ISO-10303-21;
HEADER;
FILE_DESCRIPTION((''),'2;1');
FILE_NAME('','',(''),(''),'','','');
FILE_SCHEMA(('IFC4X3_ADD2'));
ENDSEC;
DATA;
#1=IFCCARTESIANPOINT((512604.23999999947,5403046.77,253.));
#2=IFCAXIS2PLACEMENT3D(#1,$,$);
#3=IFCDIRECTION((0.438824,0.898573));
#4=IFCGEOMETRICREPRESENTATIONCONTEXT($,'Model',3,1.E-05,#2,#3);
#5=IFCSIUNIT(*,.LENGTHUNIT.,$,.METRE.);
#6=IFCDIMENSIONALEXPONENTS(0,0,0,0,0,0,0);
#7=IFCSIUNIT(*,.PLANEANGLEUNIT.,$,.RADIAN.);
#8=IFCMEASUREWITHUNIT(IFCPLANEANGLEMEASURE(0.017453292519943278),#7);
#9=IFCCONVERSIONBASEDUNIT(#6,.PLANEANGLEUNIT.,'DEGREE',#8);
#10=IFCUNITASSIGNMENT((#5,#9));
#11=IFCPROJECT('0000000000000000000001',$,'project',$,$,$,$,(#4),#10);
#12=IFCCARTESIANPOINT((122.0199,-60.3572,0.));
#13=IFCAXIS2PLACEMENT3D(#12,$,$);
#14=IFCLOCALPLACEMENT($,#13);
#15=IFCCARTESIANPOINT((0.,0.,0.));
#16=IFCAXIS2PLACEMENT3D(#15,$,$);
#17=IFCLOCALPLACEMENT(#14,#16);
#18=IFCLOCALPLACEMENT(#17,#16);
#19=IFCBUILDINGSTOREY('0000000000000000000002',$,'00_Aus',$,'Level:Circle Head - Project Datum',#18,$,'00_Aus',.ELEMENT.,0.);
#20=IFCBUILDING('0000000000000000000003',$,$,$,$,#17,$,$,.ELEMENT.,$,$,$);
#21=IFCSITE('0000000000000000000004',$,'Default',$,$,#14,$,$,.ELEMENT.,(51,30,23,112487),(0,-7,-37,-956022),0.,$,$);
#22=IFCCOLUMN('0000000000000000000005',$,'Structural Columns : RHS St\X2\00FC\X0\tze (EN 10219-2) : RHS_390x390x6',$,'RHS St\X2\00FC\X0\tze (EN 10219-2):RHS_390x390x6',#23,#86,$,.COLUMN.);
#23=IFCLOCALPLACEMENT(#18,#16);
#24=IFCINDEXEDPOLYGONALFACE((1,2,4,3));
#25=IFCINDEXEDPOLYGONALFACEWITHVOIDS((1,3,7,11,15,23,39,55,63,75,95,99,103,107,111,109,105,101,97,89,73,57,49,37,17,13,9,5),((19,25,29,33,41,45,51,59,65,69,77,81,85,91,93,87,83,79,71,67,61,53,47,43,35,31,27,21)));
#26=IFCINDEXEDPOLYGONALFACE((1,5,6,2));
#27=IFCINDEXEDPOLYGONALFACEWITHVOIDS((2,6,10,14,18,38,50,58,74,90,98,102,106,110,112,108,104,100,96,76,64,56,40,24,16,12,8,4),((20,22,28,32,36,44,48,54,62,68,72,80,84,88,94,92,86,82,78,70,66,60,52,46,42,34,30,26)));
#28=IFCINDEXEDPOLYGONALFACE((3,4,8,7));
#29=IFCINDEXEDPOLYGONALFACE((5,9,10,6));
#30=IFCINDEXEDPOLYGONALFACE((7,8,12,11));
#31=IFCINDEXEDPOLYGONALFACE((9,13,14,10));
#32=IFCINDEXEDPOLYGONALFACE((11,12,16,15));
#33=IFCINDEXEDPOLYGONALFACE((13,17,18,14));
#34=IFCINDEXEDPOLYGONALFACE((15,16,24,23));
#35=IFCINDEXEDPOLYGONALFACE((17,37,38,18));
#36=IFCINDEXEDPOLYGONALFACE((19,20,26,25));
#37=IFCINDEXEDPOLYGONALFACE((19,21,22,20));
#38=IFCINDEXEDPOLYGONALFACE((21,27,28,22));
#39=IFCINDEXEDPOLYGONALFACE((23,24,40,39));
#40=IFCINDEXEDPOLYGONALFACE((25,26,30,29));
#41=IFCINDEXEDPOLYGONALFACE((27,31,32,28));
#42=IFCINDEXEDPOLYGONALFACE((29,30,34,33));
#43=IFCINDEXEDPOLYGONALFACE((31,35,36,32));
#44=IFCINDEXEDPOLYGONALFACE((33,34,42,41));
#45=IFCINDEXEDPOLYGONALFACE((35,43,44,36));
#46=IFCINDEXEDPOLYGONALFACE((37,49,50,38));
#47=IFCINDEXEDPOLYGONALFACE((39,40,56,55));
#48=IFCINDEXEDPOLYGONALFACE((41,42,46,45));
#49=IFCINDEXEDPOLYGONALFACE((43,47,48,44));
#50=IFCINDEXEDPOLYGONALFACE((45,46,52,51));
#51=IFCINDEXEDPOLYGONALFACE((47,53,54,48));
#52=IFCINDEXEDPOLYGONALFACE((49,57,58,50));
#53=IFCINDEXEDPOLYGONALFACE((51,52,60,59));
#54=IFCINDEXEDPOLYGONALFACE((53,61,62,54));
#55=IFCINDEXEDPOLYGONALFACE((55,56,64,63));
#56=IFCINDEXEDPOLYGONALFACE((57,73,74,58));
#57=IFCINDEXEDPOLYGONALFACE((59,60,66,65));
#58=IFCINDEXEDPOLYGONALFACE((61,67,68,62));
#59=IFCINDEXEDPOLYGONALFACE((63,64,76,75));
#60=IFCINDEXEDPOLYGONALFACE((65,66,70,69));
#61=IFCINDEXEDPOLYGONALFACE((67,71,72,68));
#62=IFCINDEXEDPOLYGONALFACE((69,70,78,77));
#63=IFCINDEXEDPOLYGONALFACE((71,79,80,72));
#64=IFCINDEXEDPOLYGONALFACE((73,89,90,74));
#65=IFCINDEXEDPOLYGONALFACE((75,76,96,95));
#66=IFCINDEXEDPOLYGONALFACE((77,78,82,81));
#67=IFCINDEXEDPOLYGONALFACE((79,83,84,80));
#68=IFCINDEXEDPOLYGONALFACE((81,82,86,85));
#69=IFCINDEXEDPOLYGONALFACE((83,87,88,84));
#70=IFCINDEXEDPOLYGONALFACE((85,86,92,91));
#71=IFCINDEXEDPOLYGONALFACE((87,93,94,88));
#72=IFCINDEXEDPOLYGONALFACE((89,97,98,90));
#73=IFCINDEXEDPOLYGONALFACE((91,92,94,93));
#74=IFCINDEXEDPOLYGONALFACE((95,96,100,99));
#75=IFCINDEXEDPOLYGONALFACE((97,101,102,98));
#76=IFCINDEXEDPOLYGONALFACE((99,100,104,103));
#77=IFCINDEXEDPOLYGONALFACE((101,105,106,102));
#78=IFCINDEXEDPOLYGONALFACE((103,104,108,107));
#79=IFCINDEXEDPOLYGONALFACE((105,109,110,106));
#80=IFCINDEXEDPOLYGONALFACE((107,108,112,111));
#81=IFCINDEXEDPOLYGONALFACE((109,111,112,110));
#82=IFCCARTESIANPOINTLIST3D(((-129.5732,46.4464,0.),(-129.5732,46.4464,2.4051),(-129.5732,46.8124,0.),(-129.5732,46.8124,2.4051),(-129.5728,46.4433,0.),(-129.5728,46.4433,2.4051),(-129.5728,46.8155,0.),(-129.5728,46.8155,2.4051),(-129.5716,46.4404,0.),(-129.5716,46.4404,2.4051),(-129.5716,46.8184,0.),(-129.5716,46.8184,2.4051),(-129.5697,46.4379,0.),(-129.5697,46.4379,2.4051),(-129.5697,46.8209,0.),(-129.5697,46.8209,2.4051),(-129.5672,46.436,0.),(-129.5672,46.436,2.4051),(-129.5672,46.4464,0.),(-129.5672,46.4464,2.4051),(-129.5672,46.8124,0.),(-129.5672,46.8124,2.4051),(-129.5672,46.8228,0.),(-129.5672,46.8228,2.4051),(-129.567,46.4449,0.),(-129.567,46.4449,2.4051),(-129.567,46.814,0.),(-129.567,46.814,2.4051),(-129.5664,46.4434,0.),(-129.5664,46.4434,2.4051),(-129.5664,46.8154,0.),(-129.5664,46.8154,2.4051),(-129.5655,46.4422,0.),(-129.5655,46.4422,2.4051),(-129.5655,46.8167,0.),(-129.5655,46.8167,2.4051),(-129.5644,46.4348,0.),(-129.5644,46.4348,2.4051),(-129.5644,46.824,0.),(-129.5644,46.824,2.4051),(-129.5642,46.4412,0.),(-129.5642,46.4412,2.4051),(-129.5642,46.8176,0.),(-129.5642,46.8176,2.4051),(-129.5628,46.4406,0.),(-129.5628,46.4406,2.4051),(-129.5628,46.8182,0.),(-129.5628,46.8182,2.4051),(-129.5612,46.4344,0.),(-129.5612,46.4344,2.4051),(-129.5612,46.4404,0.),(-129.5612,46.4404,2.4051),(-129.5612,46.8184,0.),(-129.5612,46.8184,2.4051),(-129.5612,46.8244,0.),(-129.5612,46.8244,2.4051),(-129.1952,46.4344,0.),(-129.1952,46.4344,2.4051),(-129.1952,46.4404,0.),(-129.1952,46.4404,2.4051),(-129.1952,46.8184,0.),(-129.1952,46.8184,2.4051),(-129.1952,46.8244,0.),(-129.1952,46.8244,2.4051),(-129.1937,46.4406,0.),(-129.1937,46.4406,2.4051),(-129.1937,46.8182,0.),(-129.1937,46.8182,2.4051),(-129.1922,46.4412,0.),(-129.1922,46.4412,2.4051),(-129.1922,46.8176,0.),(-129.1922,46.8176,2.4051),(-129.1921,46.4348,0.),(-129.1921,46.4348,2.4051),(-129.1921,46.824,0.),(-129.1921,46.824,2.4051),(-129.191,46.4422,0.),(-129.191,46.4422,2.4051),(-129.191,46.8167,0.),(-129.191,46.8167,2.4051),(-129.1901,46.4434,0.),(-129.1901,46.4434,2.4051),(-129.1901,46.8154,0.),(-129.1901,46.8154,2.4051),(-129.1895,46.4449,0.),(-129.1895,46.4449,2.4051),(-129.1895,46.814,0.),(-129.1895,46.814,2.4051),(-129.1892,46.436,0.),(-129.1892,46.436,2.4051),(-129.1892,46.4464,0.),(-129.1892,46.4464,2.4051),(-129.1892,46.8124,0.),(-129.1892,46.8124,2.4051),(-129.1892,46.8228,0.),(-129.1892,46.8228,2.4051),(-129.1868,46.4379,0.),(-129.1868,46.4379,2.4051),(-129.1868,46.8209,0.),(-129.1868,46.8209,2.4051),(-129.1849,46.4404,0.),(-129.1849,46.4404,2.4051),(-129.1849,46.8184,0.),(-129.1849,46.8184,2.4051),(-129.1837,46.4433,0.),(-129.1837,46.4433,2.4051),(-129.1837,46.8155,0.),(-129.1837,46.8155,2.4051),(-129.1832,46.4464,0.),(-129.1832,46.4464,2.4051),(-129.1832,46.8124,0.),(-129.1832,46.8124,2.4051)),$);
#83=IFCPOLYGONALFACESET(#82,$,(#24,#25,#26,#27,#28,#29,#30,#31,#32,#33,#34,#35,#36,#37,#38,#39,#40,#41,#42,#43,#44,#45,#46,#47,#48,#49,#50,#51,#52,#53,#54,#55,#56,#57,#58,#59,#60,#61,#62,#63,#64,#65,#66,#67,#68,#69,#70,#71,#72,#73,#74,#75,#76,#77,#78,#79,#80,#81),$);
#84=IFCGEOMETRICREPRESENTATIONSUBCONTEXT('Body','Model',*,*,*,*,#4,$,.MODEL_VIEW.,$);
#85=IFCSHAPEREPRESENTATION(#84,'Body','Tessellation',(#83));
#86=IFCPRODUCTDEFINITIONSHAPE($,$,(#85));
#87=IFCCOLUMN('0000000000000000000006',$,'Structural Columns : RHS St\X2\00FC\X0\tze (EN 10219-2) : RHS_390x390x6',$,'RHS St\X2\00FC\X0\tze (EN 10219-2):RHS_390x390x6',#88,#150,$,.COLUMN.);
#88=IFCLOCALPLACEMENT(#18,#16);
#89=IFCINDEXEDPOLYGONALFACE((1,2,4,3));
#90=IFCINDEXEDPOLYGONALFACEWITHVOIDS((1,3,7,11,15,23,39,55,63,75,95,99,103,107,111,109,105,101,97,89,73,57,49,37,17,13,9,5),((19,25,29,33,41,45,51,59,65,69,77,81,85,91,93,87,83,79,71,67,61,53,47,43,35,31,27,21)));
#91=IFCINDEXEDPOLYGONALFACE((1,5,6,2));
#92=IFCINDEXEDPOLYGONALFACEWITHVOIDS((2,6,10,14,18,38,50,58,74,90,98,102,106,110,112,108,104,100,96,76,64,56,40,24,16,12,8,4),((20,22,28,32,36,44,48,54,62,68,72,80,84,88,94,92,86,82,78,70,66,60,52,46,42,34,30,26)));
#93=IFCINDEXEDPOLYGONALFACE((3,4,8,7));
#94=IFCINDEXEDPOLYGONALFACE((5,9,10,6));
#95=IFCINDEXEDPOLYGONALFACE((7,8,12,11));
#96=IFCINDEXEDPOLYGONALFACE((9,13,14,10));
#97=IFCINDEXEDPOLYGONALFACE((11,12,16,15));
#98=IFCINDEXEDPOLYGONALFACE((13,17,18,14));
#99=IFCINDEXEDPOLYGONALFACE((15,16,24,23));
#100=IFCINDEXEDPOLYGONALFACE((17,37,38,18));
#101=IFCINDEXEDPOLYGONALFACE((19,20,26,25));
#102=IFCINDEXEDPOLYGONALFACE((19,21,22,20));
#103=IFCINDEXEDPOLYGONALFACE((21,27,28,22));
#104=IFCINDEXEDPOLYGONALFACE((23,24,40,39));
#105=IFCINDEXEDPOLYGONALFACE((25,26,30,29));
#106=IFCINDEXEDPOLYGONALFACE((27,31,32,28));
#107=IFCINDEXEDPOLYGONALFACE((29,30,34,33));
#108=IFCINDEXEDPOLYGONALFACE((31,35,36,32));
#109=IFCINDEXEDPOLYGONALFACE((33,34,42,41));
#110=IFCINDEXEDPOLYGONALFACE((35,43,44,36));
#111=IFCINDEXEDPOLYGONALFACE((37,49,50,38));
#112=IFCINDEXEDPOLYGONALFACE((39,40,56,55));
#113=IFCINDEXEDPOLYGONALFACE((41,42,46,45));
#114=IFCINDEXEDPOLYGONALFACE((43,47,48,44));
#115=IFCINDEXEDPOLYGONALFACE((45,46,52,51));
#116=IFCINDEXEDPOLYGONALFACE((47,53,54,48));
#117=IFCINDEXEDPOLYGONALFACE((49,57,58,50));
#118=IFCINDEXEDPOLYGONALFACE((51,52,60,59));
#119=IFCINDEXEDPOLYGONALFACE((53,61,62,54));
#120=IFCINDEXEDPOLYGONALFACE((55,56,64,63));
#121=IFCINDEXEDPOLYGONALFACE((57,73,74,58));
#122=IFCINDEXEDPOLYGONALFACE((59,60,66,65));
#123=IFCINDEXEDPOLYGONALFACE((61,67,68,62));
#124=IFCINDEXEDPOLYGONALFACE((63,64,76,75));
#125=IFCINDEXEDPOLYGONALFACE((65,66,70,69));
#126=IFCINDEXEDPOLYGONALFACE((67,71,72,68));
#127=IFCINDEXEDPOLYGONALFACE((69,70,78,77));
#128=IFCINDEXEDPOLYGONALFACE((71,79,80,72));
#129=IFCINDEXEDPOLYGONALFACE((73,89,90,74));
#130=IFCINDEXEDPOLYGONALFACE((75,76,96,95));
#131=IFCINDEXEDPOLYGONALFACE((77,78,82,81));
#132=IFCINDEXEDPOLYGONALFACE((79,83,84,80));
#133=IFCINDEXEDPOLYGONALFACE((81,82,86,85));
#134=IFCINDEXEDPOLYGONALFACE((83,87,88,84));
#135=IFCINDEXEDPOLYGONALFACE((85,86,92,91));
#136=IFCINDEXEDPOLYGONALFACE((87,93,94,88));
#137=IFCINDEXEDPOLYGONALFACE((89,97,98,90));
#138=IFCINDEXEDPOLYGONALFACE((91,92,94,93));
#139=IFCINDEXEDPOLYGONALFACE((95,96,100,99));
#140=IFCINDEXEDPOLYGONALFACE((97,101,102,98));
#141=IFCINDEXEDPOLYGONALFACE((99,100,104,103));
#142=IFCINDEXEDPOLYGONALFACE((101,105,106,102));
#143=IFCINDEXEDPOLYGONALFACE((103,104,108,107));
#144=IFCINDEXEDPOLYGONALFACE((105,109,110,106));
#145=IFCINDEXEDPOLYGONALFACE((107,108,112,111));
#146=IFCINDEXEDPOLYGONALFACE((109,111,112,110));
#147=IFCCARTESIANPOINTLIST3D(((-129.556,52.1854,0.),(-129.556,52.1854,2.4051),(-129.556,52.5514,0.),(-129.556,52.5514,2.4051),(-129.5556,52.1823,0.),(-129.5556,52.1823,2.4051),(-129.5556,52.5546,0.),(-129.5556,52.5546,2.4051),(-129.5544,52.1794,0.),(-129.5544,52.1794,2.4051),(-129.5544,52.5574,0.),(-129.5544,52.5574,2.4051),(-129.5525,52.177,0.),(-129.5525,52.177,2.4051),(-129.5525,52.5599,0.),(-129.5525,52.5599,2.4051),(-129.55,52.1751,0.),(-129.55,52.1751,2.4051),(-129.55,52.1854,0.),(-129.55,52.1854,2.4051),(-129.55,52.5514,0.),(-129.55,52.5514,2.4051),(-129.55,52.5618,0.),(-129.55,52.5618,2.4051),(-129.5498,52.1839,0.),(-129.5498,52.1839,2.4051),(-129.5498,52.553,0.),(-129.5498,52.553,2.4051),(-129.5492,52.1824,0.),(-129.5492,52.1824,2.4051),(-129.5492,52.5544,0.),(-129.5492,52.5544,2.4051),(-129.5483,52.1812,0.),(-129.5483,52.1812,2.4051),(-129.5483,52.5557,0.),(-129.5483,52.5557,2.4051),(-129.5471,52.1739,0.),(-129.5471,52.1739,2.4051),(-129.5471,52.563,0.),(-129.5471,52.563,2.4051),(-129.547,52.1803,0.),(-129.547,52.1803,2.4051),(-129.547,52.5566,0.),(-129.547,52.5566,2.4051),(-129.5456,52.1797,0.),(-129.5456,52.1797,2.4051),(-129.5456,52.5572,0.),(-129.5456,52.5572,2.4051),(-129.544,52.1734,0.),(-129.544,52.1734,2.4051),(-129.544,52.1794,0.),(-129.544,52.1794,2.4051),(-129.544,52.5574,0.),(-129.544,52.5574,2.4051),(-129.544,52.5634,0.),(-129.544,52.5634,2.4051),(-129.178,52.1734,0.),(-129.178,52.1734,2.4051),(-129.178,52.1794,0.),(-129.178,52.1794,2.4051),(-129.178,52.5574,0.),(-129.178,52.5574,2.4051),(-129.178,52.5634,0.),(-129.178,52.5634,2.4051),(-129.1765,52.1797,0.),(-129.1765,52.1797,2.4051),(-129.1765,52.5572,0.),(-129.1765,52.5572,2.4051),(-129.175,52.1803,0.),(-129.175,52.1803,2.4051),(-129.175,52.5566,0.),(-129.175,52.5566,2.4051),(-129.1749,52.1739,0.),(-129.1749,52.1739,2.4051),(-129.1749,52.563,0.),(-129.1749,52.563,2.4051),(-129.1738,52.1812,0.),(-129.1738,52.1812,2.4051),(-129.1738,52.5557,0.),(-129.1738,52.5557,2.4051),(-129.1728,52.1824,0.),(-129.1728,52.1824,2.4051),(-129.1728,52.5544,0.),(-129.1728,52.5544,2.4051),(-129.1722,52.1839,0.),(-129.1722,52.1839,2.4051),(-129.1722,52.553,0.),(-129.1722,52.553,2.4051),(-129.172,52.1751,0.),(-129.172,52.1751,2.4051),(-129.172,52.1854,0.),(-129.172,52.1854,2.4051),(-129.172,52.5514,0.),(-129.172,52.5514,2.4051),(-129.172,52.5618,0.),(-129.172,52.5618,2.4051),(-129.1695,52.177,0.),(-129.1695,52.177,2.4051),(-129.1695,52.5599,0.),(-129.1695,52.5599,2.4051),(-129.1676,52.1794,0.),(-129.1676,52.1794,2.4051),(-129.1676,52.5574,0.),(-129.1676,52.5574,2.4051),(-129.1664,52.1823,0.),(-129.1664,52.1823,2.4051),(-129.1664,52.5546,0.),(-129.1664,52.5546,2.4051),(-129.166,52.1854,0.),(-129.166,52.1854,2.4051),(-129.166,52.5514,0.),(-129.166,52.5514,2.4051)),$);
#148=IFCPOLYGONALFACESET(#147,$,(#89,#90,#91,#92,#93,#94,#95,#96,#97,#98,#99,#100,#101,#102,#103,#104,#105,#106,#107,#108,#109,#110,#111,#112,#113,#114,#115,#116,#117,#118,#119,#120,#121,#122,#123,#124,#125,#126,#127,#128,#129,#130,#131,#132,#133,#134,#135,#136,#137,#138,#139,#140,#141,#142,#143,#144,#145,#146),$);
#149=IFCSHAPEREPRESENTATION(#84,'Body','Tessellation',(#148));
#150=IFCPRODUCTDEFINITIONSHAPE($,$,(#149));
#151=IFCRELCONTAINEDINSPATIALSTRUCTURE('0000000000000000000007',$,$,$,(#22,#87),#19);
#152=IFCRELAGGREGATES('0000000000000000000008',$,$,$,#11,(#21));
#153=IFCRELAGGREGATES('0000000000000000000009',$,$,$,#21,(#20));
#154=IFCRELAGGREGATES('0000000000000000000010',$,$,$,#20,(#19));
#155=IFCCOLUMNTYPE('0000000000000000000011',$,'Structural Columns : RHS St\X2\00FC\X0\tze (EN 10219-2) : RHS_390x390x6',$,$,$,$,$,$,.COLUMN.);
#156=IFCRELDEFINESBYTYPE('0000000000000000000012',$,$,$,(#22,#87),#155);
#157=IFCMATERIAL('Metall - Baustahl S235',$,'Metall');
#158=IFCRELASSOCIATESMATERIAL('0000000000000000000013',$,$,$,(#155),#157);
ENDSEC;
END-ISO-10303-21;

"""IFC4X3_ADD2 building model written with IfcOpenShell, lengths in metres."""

from ifc_helpers import new_model, entity, si_unit, converted_unit, direction, frame, frame_2d, origin, place, context, subcontext, project, spatial, polyline, circle_curve, parameter, trimmed, segment, composite_curve, outline, extrude, source, transform, mapped, material, material_profile, profile_set, type_object, type_shapes, element, save


model = new_model("IFC4X3_ADD2")

# Units and contexts
model_context = context("Model", 3, precision=1e-05, world=frame((512604.23999999947, 5403046.77, 253.0)), true_north=direction((0.438824, 0.898573)))
body_context = subcontext(model_context, "Body", "Model", "MODEL_VIEW")
ifc_project = project(units=[si_unit("LENGTHUNIT", "METRE"), converted_unit("PLANEANGLEUNIT", "DEGREE", entity("IfcPlaneAngleMeasure", 0.017453292519943278), si_unit("PLANEANGLEUNIT", "RADIAN"), dimensions=[0, 0, 0, 0, 0, 0, 0])], contexts=[model_context])

# Site, building, storey
site_placement = place(None, frame((122.0199, -60.3572, 0.0)))
site = spatial("IfcSite", under=ifc_project, at=site_placement, Name="Default", CompositionType="ELEMENT", RefLatitude=(51, 30, 23, 112487), RefLongitude=(0, -7, -37, -956022), RefElevation=0.0)
building_placement = place(site_placement, origin())
building = spatial("IfcBuilding", under=site, at=building_placement, CompositionType="ELEMENT")
storey_placement = place(building_placement, origin())
storey = spatial("IfcBuildingStorey", under=building, at=storey_placement, Name="00_Aus", ObjectType="Level:Circle Head - Project Datum", LongName="00_Aus", CompositionType="ELEMENT", Elevation=0.0)

# Columns
ifc_material_1 = material(Name="Metall - Baustahl S235", Category="Metall")
ifc_material_profile_1 = material_profile(ifc_material_1, outline(composite_curve([segment(polyline([(-0.183, -0.195), (0.183, -0.195)]), True, "CONTINUOUS"), segment(trimmed(circle_curve(frame_2d((0.183, -0.183), x_axis=(-1.0, 0.0)), 0.012), [parameter(90.0)], [parameter(180.0)], True, "PARAMETER"), True, "CONTINUOUS"), segment(polyline([(0.195, -0.183), (0.195, 0.183)]), True, "CONTINUOUS"), segment(trimmed(circle_curve(frame_2d((0.183, 0.183), x_axis=(-1.0, 0.0)), 0.012), [parameter(180.0)], [parameter(270.0)], True, "PARAMETER"), True, "CONTINUOUS"), segment(polyline([(0.183, 0.195), (-0.183, 0.195)]), True, "CONTINUOUS"), segment(trimmed(circle_curve(frame_2d((-0.183, 0.183), x_axis=(-1.0, 0.0)), 0.012), [parameter(270.0)], [parameter(360.0)], True, "PARAMETER"), True, "CONTINUOUS"), segment(polyline([(-0.195, 0.183), (-0.195, -0.183)]), True, "CONTINUOUS"), segment(trimmed(circle_curve(frame_2d((-0.183, -0.183), x_axis=(-1.0, 0.0)), 0.012), [parameter(360.0)], [parameter(90.0)], True, "PARAMETER"), True, "CONTINUOUS")], self_intersect=False), holes=[composite_curve([segment(trimmed(circle_curve(frame_2d((-0.183, -0.183), x_axis=(-1.0, 0.0)), 0.006), [parameter(0.0)], [parameter(90.0)], True, "PARAMETER"), False, "CONTINUOUS"), segment(polyline([(-0.189, -0.183), (-0.189, 0.183)]), True, "CONTINUOUS"), segment(trimmed(circle_curve(frame_2d((-0.183, 0.183), x_axis=(-1.0, 0.0)), 0.006), [parameter(270.0)], [parameter(0.0)], True, "PARAMETER"), False, "CONTINUOUS"), segment(polyline([(-0.183, 0.189), (0.183, 0.189)]), True, "CONTINUOUS"), segment(trimmed(circle_curve(frame_2d((0.183, 0.183), x_axis=(-1.0, 0.0)), 0.006), [parameter(180.0)], [parameter(270.0)], True, "PARAMETER"), False, "CONTINUOUS"), segment(polyline([(0.189, 0.183), (0.189, -0.183)]), True, "CONTINUOUS"), segment(trimmed(circle_curve(frame_2d((0.183, -0.183), x_axis=(-1.0, 0.0)), 0.006), [parameter(90.0)], [parameter(180.0)], True, "PARAMETER"), False, "CONTINUOUS"), segment(polyline([(0.183, -0.189), (-0.183, -0.189)]), True, "CONTINUOUS")], self_intersect=False)]), Name="RHS_390x390x6")
ifc_profile_set_1 = profile_set([ifc_material_profile_1], Name="RHS_390x390x6")
column_type_1 = type_object("IfcColumnType", Name="Structural Columns : RHS Stütze (EN 10219-2) : RHS_390x390x6", PredefinedType="COLUMN", material=ifc_profile_set_1)
shared_shape_1 = source(origin(), body_context, "Body", "SweptSolid", [
    extrude(outline(composite_curve([segment(polyline([(-0.183, -0.195), (0.183, -0.195)]), True, "CONTINUOUS"), segment(trimmed(circle_curve(frame_2d((0.183, -0.183), x_axis=(-1.0, 0.0)), 0.012), [parameter(90.0)], [parameter(180.0)], True, "PARAMETER"), True, "CONTINUOUS"), segment(polyline([(0.195, -0.183), (0.195, 0.183)]), True, "CONTINUOUS"), segment(trimmed(circle_curve(frame_2d((0.183, 0.183), x_axis=(-1.0, 0.0)), 0.012), [parameter(180.0)], [parameter(270.0)], True, "PARAMETER"), True, "CONTINUOUS"), segment(polyline([(0.183, 0.195), (-0.183, 0.195)]), True, "CONTINUOUS"), segment(trimmed(circle_curve(frame_2d((-0.183, 0.183), x_axis=(-1.0, 0.0)), 0.012), [parameter(270.0)], [parameter(360.0)], True, "PARAMETER"), True, "CONTINUOUS"), segment(polyline([(-0.195, 0.183), (-0.195, -0.183)]), True, "CONTINUOUS"), segment(trimmed(circle_curve(frame_2d((-0.183, -0.183), x_axis=(-1.0, 0.0)), 0.012), [parameter(360.0)], [parameter(90.0)], True, "PARAMETER"), True, "CONTINUOUS")], self_intersect=False), holes=[composite_curve([segment(trimmed(circle_curve(frame_2d((-0.183, -0.183), x_axis=(-1.0, 0.0)), 0.006), [parameter(0.0)], [parameter(90.0)], True, "PARAMETER"), False, "CONTINUOUS"), segment(polyline([(-0.189, -0.183), (-0.189, 0.183)]), True, "CONTINUOUS"), segment(trimmed(circle_curve(frame_2d((-0.183, 0.183), x_axis=(-1.0, 0.0)), 0.006), [parameter(270.0)], [parameter(360.0)], True, "PARAMETER"), False, "CONTINUOUS"), segment(polyline([(-0.183, 0.189), (0.183, 0.189)]), True, "CONTINUOUS"), segment(trimmed(circle_curve(frame_2d((0.183, 0.183), x_axis=(-1.0, 0.0)), 0.006), [parameter(180.0)], [parameter(270.0)], True, "PARAMETER"), False, "CONTINUOUS"), segment(polyline([(0.189, 0.183), (0.189, -0.183)]), True, "CONTINUOUS"), segment(trimmed(circle_curve(frame_2d((0.183, -0.183), x_axis=(-1.0, 0.0)), 0.006), [parameter(90.0)], [parameter(180.0)], True, "PARAMETER"), False, "CONTINUOUS"), segment(polyline([(0.183, -0.189), (-0.183, -0.189)]), True, "CONTINUOUS")], self_intersect=False)]), frame((0.0, 0.0, 0.0), z_axis=(0.0, 0.0, 1.0), x_axis=(-1.0, 0.0, 0.0)), (0.0, 0.0, 1.0), 2.4051),
])
type_shapes(column_type_1, [shared_shape_1])
for number, where, name in (
    (1, (-129.3782, 46.6294, 0.0), "Structural Columns : RHS Stütze (EN 10219-2) : RHS_390x390x6"),
    (2, (-129.361, 52.3684, 0.0), "Structural Columns : RHS Stütze (EN 10219-2) : RHS_390x390x6"),
):
    element("IfcColumn", number, at=place(storey_placement, frame(where)), inside=storey, type_object=column_type_1, Name=name, ObjectType="RHS Stütze (EN 10219-2):RHS_390x390x6", PredefinedType="COLUMN", context=body_context, shape_type="MappedRepresentation", body=[
        mapped(shared_shape_1, transform((0.0, 0.0, 0.0), scale=1.0)),
    ])

save(model, "model.ifc")
